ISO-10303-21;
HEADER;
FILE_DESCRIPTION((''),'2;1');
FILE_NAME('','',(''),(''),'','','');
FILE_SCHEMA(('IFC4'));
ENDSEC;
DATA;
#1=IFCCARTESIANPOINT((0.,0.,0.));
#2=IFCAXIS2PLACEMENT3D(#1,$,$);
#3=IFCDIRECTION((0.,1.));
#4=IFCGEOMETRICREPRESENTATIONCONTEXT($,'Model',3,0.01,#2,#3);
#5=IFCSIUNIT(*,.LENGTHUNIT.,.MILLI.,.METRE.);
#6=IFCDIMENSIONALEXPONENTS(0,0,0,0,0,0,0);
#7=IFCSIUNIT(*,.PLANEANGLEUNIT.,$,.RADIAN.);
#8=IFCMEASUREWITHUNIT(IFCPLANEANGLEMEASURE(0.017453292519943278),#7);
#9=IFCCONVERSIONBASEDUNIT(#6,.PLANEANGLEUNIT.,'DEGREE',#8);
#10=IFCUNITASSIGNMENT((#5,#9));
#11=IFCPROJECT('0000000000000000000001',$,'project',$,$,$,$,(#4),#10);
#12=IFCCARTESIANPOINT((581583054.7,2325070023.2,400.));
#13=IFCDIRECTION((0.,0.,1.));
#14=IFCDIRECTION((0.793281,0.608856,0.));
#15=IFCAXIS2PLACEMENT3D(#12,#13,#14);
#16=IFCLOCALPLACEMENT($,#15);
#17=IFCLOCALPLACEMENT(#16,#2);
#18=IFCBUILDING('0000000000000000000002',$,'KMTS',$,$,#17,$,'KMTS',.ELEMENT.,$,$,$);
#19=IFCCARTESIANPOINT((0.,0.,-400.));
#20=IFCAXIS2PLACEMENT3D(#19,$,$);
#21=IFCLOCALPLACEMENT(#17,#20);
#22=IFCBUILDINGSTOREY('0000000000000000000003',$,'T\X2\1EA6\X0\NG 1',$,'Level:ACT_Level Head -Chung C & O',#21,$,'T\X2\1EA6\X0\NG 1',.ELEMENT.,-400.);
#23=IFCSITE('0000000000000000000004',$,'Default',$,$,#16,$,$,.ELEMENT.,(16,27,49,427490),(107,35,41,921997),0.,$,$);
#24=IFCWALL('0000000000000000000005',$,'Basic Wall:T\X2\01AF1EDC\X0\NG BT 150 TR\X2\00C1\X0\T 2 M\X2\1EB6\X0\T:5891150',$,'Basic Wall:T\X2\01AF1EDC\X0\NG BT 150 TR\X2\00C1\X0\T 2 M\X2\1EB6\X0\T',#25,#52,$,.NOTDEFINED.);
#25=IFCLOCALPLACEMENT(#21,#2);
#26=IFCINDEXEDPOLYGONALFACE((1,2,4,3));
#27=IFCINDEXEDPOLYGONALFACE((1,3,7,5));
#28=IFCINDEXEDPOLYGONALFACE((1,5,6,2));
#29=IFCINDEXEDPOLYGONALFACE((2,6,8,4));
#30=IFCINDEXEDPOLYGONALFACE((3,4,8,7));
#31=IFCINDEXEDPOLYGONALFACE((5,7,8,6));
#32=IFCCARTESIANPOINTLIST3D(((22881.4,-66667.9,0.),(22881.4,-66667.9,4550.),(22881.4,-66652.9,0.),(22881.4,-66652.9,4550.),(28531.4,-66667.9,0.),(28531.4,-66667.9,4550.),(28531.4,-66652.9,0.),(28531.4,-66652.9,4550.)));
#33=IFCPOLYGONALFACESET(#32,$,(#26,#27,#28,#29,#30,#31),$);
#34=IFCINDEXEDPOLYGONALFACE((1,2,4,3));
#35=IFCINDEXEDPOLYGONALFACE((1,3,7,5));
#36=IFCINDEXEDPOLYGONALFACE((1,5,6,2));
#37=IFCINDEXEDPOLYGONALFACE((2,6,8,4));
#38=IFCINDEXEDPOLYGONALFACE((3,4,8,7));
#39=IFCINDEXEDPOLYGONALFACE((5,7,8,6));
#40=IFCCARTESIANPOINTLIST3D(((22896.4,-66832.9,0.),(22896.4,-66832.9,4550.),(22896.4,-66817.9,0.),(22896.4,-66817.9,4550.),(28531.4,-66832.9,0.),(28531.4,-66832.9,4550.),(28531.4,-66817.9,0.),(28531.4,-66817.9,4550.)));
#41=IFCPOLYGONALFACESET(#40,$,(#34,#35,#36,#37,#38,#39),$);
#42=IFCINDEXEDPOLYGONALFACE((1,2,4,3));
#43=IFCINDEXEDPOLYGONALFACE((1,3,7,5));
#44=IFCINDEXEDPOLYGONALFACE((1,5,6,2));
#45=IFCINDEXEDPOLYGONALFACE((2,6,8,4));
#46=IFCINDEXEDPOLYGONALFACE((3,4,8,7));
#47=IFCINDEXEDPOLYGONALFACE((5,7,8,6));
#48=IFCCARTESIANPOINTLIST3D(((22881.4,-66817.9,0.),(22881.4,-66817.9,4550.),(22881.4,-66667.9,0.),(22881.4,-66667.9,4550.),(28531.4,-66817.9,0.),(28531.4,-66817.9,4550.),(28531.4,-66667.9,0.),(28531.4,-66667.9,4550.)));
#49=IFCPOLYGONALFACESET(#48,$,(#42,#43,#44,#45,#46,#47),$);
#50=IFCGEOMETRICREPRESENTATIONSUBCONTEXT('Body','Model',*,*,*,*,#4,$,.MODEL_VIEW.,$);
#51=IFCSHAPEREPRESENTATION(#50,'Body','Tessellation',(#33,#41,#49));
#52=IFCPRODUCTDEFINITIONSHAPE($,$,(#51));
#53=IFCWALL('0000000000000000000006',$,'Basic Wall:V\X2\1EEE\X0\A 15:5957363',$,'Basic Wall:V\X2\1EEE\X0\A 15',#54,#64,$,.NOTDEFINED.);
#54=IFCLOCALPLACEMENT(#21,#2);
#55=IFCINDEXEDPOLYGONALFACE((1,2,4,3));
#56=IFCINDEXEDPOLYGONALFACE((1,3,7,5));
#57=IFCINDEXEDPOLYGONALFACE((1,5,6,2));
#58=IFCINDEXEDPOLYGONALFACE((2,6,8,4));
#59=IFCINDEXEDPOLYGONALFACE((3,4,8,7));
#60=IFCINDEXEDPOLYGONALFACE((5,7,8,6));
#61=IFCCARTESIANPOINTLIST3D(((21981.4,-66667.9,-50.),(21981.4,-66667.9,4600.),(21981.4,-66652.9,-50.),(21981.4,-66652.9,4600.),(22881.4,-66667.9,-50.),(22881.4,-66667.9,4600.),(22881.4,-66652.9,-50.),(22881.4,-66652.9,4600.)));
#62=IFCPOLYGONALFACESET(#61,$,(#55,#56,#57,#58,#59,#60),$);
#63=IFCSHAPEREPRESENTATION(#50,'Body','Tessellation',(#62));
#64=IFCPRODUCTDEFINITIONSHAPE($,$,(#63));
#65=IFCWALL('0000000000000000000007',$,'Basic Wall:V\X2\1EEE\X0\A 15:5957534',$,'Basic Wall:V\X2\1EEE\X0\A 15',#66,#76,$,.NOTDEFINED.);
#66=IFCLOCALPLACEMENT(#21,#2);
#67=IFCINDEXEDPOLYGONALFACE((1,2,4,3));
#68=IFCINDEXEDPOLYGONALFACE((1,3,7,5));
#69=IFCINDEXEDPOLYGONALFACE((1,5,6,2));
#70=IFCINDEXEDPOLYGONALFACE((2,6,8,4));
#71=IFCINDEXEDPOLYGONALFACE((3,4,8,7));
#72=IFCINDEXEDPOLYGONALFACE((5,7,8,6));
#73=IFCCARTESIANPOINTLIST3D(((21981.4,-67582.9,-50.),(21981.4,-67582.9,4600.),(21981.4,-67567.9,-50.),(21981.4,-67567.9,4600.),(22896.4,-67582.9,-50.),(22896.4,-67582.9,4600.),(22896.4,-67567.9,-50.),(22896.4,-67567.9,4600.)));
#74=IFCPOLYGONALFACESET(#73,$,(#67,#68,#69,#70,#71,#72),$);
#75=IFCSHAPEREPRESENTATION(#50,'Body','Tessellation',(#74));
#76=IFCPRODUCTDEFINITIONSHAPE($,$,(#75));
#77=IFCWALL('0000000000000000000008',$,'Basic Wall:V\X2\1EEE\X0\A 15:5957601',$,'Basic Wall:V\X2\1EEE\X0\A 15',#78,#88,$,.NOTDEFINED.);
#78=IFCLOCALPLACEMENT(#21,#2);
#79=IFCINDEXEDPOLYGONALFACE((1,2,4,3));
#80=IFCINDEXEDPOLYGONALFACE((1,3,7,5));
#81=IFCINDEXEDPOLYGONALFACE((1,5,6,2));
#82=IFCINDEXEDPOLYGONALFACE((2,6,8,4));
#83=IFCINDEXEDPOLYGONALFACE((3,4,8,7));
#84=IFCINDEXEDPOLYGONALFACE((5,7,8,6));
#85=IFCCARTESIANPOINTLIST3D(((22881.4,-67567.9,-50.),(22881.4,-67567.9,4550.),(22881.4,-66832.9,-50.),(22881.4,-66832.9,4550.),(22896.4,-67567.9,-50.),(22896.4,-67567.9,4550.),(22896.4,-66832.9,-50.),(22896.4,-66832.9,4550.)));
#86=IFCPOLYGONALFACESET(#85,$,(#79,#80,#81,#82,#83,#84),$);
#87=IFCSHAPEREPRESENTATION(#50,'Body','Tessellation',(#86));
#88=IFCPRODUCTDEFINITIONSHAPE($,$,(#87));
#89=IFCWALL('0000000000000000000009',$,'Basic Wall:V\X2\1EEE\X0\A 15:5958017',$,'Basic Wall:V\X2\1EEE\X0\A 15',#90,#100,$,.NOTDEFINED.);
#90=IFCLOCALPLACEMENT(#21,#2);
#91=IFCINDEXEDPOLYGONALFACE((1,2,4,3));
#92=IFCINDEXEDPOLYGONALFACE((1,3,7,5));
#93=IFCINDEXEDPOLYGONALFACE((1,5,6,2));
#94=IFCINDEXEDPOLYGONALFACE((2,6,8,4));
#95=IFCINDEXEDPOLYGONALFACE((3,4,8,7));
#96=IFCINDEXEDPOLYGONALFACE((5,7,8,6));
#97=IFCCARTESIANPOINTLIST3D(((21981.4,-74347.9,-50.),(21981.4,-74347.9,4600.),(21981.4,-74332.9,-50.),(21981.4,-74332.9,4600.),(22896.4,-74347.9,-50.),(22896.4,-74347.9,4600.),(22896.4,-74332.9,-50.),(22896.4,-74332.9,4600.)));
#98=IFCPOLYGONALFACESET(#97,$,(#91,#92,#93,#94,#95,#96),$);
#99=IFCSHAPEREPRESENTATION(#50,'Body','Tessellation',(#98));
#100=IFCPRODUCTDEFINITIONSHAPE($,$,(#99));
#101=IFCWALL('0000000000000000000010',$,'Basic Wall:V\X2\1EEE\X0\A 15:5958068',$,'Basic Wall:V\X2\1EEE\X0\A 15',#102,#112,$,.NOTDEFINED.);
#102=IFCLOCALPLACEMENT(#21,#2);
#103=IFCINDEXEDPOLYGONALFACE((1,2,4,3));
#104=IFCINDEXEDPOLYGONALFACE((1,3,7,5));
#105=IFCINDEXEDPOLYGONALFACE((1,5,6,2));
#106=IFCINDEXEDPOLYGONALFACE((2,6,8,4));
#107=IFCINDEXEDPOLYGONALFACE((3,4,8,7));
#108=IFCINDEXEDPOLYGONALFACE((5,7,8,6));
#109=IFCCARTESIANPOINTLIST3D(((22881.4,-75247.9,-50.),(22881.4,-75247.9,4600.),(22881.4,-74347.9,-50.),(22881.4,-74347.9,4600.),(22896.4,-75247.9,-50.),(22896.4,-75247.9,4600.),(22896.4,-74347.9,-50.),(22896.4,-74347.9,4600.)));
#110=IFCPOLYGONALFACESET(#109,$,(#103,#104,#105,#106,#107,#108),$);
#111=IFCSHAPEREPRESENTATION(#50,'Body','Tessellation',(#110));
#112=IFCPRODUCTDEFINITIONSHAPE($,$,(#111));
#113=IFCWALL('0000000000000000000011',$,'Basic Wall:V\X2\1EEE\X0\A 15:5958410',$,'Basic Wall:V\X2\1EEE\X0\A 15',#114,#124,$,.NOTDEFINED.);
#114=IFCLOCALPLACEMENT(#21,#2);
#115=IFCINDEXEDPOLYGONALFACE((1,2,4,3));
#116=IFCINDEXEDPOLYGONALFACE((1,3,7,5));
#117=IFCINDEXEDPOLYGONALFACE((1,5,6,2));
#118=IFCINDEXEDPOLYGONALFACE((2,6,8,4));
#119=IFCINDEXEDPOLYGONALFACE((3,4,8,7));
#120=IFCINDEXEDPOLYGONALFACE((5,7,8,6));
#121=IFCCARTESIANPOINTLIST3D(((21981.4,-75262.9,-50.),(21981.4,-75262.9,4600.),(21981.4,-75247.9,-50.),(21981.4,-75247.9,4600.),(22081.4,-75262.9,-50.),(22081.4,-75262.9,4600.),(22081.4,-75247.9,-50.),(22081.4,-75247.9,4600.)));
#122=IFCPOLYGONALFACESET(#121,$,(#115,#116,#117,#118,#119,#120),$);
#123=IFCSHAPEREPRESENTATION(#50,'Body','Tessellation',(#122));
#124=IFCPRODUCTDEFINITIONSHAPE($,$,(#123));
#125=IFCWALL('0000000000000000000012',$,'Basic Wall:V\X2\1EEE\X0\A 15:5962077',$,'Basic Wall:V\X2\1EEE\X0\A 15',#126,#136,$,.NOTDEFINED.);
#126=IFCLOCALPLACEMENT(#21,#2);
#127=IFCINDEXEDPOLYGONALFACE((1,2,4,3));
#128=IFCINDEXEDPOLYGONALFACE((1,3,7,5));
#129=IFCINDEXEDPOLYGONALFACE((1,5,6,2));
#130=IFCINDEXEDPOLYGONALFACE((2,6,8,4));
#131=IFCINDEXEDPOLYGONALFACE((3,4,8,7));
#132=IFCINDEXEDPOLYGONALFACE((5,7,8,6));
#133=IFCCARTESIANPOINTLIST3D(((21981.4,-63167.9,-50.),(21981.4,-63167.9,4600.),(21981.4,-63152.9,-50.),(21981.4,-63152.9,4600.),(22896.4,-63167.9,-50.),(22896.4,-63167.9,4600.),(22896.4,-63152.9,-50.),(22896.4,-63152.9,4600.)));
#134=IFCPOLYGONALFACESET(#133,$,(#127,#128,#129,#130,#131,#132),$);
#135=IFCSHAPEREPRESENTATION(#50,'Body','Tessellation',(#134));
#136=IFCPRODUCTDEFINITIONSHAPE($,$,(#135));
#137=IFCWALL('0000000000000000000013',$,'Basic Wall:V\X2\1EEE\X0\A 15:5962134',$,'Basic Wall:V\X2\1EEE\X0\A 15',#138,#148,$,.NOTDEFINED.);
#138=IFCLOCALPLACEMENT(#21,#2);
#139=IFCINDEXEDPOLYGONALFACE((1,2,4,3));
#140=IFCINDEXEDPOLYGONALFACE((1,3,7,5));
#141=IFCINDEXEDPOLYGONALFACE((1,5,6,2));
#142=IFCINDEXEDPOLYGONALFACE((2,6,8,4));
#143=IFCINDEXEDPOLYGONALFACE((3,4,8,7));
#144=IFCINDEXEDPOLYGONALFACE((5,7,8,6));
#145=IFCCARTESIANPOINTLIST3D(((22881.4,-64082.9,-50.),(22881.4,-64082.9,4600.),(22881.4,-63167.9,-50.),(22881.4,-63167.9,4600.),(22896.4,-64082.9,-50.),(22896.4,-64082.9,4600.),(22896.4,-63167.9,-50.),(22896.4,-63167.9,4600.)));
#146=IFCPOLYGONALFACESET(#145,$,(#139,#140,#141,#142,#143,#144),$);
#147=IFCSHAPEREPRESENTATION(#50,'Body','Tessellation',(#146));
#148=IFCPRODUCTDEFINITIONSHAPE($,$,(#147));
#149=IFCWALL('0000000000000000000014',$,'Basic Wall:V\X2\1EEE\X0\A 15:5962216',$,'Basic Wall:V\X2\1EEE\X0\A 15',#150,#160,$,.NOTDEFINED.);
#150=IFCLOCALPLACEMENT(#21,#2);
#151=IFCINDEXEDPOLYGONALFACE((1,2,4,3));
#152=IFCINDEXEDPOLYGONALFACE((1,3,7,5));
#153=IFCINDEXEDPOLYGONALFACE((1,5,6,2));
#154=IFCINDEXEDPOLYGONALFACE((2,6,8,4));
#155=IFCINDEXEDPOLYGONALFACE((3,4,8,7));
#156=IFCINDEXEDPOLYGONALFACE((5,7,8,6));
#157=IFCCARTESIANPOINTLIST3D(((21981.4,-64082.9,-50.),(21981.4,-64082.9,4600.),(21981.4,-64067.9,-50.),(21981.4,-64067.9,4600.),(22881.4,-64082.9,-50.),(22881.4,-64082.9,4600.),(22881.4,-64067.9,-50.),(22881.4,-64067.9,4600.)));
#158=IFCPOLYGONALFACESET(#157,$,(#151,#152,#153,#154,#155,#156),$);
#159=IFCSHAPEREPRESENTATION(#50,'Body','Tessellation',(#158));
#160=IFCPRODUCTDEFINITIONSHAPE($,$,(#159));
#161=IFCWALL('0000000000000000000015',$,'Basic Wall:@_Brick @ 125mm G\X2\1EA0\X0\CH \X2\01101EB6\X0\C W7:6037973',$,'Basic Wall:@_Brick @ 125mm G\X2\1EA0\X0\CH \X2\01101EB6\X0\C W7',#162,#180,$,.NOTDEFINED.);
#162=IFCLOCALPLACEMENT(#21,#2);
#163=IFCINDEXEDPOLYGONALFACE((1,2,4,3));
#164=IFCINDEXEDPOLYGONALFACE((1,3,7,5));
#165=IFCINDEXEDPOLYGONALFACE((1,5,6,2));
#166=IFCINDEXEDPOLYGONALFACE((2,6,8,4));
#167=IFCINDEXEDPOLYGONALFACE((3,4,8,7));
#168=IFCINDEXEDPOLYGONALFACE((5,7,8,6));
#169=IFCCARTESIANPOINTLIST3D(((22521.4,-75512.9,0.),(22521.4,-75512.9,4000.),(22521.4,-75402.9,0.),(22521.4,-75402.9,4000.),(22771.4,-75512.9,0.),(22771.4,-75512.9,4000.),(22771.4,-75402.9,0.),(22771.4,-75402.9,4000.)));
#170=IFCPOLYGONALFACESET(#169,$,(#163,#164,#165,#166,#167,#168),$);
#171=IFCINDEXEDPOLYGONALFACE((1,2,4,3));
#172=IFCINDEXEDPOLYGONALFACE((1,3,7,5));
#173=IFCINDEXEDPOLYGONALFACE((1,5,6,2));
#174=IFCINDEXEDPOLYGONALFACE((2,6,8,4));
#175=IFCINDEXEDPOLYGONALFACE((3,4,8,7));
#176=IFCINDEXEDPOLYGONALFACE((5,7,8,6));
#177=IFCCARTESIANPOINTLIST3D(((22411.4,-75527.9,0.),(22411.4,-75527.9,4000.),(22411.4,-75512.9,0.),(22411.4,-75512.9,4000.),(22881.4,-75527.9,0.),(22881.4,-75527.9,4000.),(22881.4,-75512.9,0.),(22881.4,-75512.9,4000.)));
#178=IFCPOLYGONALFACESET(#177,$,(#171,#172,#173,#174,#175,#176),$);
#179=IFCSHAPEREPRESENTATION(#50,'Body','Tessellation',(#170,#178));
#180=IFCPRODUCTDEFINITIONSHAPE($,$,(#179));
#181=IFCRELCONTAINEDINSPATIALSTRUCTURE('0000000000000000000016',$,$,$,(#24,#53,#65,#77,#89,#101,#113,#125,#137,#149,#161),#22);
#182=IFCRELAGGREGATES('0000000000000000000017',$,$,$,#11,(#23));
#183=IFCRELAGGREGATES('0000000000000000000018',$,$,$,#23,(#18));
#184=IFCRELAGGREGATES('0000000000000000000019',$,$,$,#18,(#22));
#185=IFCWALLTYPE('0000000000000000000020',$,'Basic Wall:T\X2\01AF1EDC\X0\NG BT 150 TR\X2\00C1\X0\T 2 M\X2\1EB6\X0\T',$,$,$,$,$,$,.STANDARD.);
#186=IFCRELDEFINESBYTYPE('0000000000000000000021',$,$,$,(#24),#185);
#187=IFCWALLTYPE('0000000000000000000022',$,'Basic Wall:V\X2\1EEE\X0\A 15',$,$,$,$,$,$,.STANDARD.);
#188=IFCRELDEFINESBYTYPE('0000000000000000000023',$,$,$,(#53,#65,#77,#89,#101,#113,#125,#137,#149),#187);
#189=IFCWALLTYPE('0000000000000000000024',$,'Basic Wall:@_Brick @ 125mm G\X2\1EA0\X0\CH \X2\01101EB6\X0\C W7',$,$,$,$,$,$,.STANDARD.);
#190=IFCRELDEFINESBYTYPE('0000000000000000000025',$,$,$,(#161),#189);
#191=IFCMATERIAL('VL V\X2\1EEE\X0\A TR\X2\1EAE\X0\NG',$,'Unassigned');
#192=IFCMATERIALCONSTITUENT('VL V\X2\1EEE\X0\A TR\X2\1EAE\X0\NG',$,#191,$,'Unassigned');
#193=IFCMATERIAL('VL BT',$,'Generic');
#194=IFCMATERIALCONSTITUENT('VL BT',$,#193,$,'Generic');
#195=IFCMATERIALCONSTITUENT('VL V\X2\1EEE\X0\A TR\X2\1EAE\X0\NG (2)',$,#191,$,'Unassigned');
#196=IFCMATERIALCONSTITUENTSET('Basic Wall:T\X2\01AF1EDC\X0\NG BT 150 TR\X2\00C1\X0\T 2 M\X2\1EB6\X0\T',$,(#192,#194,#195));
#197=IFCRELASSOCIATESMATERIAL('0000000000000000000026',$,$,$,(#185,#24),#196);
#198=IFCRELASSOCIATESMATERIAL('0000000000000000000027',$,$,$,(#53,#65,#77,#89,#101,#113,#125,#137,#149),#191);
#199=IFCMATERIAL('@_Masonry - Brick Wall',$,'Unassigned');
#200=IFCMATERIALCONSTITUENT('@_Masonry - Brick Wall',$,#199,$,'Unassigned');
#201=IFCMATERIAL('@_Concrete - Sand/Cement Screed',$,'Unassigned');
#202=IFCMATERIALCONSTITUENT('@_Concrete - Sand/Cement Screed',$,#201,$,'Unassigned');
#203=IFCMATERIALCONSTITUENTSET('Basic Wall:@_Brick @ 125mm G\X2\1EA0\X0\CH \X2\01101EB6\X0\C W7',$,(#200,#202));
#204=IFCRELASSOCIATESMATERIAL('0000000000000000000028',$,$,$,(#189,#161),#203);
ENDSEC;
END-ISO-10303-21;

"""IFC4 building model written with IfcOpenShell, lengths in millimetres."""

from ifc_helpers import new_model, entity, si_unit, converted_unit, direction, frame, origin, place, context, subcontext, project, spatial, indexed_curve, outline, extrude, material, constituent, constituent_set, type_object, element, save


model = new_model("IFC4")

# Units and contexts
model_context = context("Model", 3, precision=0.01, world=origin(), true_north=direction((0.0, 1.0)))
body_context = subcontext(model_context, "Body", "Model", "MODEL_VIEW")
ifc_project = project(units=[si_unit("LENGTHUNIT", "METRE", prefix="MILLI"), converted_unit("PLANEANGLEUNIT", "DEGREE", entity("IfcPlaneAngleMeasure", 0.017453292519943278), si_unit("PLANEANGLEUNIT", "RADIAN"), dimensions=[0, 0, 0, 0, 0, 0, 0])], contexts=[model_context])

# Site, building, storey
site_placement = place(None, frame((581583054.7, 2325070023.2, 400.0), z_axis=(0.0, 0.0, 1.0), x_axis=(0.793281, 0.608856, 0.0)))
site = spatial("IfcSite", under=ifc_project, at=site_placement, Name="Default", CompositionType="ELEMENT", RefLatitude=(16, 27, 49, 427490), RefLongitude=(107, 35, 41, 921997), RefElevation=0.0)
building_placement = place(site_placement, origin())
building = spatial("IfcBuilding", under=site, at=building_placement, Name="KMTS", LongName="KMTS", CompositionType="ELEMENT")
storey_placement = place(building_placement, frame((0.0, 0.0, -400.0)))
storey = spatial("IfcBuildingStorey", under=building, at=storey_placement, Name="TẦNG 1", ObjectType="Level:ACT_Level Head -Chung C & O", LongName="TẦNG 1", CompositionType="ELEMENT", Elevation=-400.0)

# Walls
ifc_material_1 = material(Name="VL VỮA TRẮNG", Category="Unassigned")
ifc_constituent_1 = constituent(ifc_material_1, Name="VL VỮA TRẮNG", Category="Unassigned")
ifc_material_2 = material(Name="VL BT", Category="Generic")
ifc_constituent_2 = constituent(ifc_material_2, Name="VL BT", Category="Generic")
ifc_constituent_3 = constituent(ifc_material_1, Name="VL VỮA TRẮNG (2)", Category="Unassigned")
ifc_constituent_set_1 = constituent_set(constituents=[ifc_constituent_1, ifc_constituent_2, ifc_constituent_3], Name="Basic Wall:TƯỜNG BT 150 TRÁT 2 MẶT")
wall_type_1 = type_object("IfcWallType", Name="Basic Wall:TƯỜNG BT 150 TRÁT 2 MẶT", PredefinedType="STANDARD", material=ifc_constituent_set_1)
wall_1_placement = place(storey_placement, frame((22881.4, -66742.9, 0.0)))
element("IfcWall", 1, at=wall_1_placement, inside=storey, type_object=wall_type_1, material=ifc_constituent_set_1, Name="Basic Wall:TƯỜNG BT 150 TRÁT 2 MẶT:5891150", ObjectType="Basic Wall:TƯỜNG BT 150 TRÁT 2 MẶT", PredefinedType="NOTDEFINED", context=body_context, shape_type="SweptSolid", body=[
    extrude(outline(indexed_curve([(-7.5, -2825.0), (7.5, -2825.0), (7.5, 2825.0), (-7.5, 2825.0), (-7.5, -2825.0)], self_intersect=False)), frame((2825.0, 82.5, 0.0), z_axis=(0.0, 0.0, 1.0), x_axis=(0.0, -1.0, 0.0)), (0.0, 0.0, 1.0), 4550.0),
    extrude(outline(indexed_curve([(-7.5, -2817.5), (7.5, -2817.5), (7.5, 2817.5), (-7.5, 2817.5), (-7.5, -2817.5)], self_intersect=False)), frame((2832.5, -82.5, 0.0), z_axis=(0.0, 0.0, 1.0), x_axis=(0.0, 1.0, 0.0)), (0.0, 0.0, 1.0), 4550.0),
    extrude(outline(indexed_curve([(-2825.0, -75.0), (2825.0, -75.0), (2825.0, 75.0), (-2825.0, 75.0), (-2825.0, -75.0)], self_intersect=False)), frame((2825.0, 0.0, 0.0)), (0.0, 0.0, 1.0), 4550.0),
])
wall_type_2 = type_object("IfcWallType", Name="Basic Wall:VỮA 15", PredefinedType="STANDARD")
wall_2_placement = place(storey_placement, frame((22881.4, -66660.4, -50.0), z_axis=(0.0, 0.0, 1.0), x_axis=(-1.0, 0.0, 0.0)))
element("IfcWall", 2, at=wall_2_placement, inside=storey, type_object=wall_type_2, material=ifc_material_1, Name="Basic Wall:VỮA 15:5957363", ObjectType="Basic Wall:VỮA 15", PredefinedType="NOTDEFINED", context=body_context, shape_type="SweptSolid", body=[
    extrude(outline(indexed_curve([(900.0, 7.5), (0.0, 7.5), (0.0, -7.5), (900.0, -7.5), (900.0, 7.5)], self_intersect=False)), origin(), (0.0, 0.0, 1.0), 4650.0),
])
wall_3_placement = place(storey_placement, frame((21981.4, -67575.4, -50.0)))
element("IfcWall", 3, at=wall_3_placement, inside=storey, type_object=wall_type_2, material=ifc_material_1, Name="Basic Wall:VỮA 15:5957534", ObjectType="Basic Wall:VỮA 15", PredefinedType="NOTDEFINED", context=body_context, shape_type="SweptSolid", body=[
    extrude(outline(indexed_curve([(915.0, 7.5), (0.0, 7.5), (0.0, -7.5), (915.0, -7.5), (915.0, 7.5)], self_intersect=False)), origin(), (0.0, 0.0, 1.0), 4650.0),
])
wall_4_placement = place(storey_placement, frame((22888.9, -67567.9, -50.0), z_axis=(0.0, 0.0, 1.0), x_axis=(0.0, 1.0, 0.0)))
element("IfcWall", 4, at=wall_4_placement, inside=storey, type_object=wall_type_2, material=ifc_material_1, Name="Basic Wall:VỮA 15:5957601", ObjectType="Basic Wall:VỮA 15", PredefinedType="NOTDEFINED", context=body_context, shape_type="SweptSolid", body=[
    extrude(outline(indexed_curve([(735.0, 7.5), (0.0, 7.5), (0.0, -7.5), (735.0, -7.5), (735.0, 7.5)], self_intersect=False)), origin(), (0.0, 0.0, 1.0), 4600.0),
])
wall_5_placement = place(storey_placement, frame((21981.4, -74340.4, -50.0)))
element("IfcWall", 5, at=wall_5_placement, inside=storey, type_object=wall_type_2, material=ifc_material_1, Name="Basic Wall:VỮA 15:5958017", ObjectType="Basic Wall:VỮA 15", PredefinedType="NOTDEFINED", context=body_context, shape_type="SweptSolid", body=[
    extrude(outline(indexed_curve([(915.0, 7.5), (0.0, 7.5), (0.0, -7.5), (915.0, -7.5), (915.0, 7.5)], self_intersect=False)), origin(), (0.0, 0.0, 1.0), 4650.0),
])
wall_6_placement = place(storey_placement, frame((22888.9, -74347.9, -50.0), z_axis=(0.0, 0.0, 1.0), x_axis=(0.0, -1.0, 0.0)))
element("IfcWall", 6, at=wall_6_placement, inside=storey, type_object=wall_type_2, material=ifc_material_1, Name="Basic Wall:VỮA 15:5958068", ObjectType="Basic Wall:VỮA 15", PredefinedType="NOTDEFINED", context=body_context, shape_type="SweptSolid", body=[
    extrude(outline(indexed_curve([(900.0, 7.5), (0.0, 7.5), (0.0, -7.5), (900.0, -7.5), (900.0, 7.5)], self_intersect=False)), origin(), (0.0, 0.0, 1.0), 4650.0),
])
wall_7_placement = place(storey_placement, frame((21981.4, -75255.4, -50.0)))
element("IfcWall", 7, at=wall_7_placement, inside=storey, type_object=wall_type_2, material=ifc_material_1, Name="Basic Wall:VỮA 15:5958410", ObjectType="Basic Wall:VỮA 15", PredefinedType="NOTDEFINED", context=body_context, shape_type="SweptSolid", body=[
    extrude(outline(indexed_curve([(100.0, 7.5), (0.0, 7.5), (0.0, -7.5), (100.0, -7.5), (100.0, 7.5)], self_intersect=False)), origin(), (0.0, 0.0, 1.0), 4650.0),
])
wall_8_placement = place(storey_placement, frame((21981.4, -63160.4, -50.0)))
element("IfcWall", 8, at=wall_8_placement, inside=storey, type_object=wall_type_2, material=ifc_material_1, Name="Basic Wall:VỮA 15:5962077", ObjectType="Basic Wall:VỮA 15", PredefinedType="NOTDEFINED", context=body_context, shape_type="SweptSolid", body=[
    extrude(outline(indexed_curve([(915.0, 7.5), (0.0, 7.5), (0.0, -7.5), (915.0, -7.5), (915.0, 7.5)], self_intersect=False)), origin(), (0.0, 0.0, 1.0), 4650.0),
])
wall_9_placement = place(storey_placement, frame((22888.9, -63167.9, -50.0), z_axis=(0.0, 0.0, 1.0), x_axis=(0.0, -1.0, 0.0)))
element("IfcWall", 9, at=wall_9_placement, inside=storey, type_object=wall_type_2, material=ifc_material_1, Name="Basic Wall:VỮA 15:5962134", ObjectType="Basic Wall:VỮA 15", PredefinedType="NOTDEFINED", context=body_context, shape_type="SweptSolid", body=[
    extrude(outline(indexed_curve([(915.0, 7.5), (0.0, 7.5), (0.0, -7.5), (915.0, -7.5), (915.0, 7.5)], self_intersect=False)), origin(), (0.0, 0.0, 1.0), 4650.0),
])
wall_10_placement = place(storey_placement, frame((22881.4, -64075.4, -50.0), z_axis=(0.0, 0.0, 1.0), x_axis=(-1.0, 0.0, 0.0)))
element("IfcWall", 10, at=wall_10_placement, inside=storey, type_object=wall_type_2, material=ifc_material_1, Name="Basic Wall:VỮA 15:5962216", ObjectType="Basic Wall:VỮA 15", PredefinedType="NOTDEFINED", context=body_context, shape_type="SweptSolid", body=[
    extrude(outline(indexed_curve([(900.0, 7.5), (0.0, 7.5), (0.0, -7.5), (900.0, -7.5), (900.0, 7.5)], self_intersect=False)), origin(), (0.0, 0.0, 1.0), 4650.0),
])
ifc_material_3 = material(Name="@_Masonry - Brick Wall", Category="Unassigned")
ifc_constituent_4 = constituent(ifc_material_3, Name="@_Masonry - Brick Wall", Category="Unassigned")
ifc_material_4 = material(Name="@_Concrete - Sand/Cement Screed", Category="Unassigned")
ifc_constituent_5 = constituent(ifc_material_4, Name="@_Concrete - Sand/Cement Screed", Category="Unassigned")
ifc_constituent_set_2 = constituent_set(constituents=[ifc_constituent_4, ifc_constituent_5], Name="Basic Wall:@_Brick @ 125mm GẠCH ĐẶC W7")
wall_type_3 = type_object("IfcWallType", Name="Basic Wall:@_Brick @ 125mm GẠCH ĐẶC W7", PredefinedType="STANDARD", material=ifc_constituent_set_2)
wall_11_placement = place(storey_placement, frame((22521.4, -75465.4, 0.0)))
element("IfcWall", 11, at=wall_11_placement, inside=storey, type_object=wall_type_3, material=ifc_constituent_set_2, Name="Basic Wall:@_Brick @ 125mm GẠCH ĐẶC W7:6037973", ObjectType="Basic Wall:@_Brick @ 125mm GẠCH ĐẶC W7", PredefinedType="NOTDEFINED", context=body_context, shape_type="SweptSolid", body=[
    extrude(outline(indexed_curve([(-55.0, -125.0), (55.0, -125.0), (55.0, 125.0), (-55.0, 125.0), (-55.0, -125.0)], self_intersect=False)), frame((125.0, 7.5, 0.0), z_axis=(0.0, 0.0, 1.0), x_axis=(0.0, -1.0, 0.0)), (0.0, 0.0, 1.0), 4000.0),
    extrude(outline(indexed_curve([(-7.5, -235.0), (7.5, -235.0), (7.5, 235.0), (-7.5, 235.0), (-7.5, -235.0)], self_intersect=False)), frame((125.0, -55.0, 0.0), z_axis=(0.0, 0.0, 1.0), x_axis=(0.0, 1.0, 0.0)), (0.0, 0.0, 1.0), 4000.0),
])

save(model, "model.ifc")
